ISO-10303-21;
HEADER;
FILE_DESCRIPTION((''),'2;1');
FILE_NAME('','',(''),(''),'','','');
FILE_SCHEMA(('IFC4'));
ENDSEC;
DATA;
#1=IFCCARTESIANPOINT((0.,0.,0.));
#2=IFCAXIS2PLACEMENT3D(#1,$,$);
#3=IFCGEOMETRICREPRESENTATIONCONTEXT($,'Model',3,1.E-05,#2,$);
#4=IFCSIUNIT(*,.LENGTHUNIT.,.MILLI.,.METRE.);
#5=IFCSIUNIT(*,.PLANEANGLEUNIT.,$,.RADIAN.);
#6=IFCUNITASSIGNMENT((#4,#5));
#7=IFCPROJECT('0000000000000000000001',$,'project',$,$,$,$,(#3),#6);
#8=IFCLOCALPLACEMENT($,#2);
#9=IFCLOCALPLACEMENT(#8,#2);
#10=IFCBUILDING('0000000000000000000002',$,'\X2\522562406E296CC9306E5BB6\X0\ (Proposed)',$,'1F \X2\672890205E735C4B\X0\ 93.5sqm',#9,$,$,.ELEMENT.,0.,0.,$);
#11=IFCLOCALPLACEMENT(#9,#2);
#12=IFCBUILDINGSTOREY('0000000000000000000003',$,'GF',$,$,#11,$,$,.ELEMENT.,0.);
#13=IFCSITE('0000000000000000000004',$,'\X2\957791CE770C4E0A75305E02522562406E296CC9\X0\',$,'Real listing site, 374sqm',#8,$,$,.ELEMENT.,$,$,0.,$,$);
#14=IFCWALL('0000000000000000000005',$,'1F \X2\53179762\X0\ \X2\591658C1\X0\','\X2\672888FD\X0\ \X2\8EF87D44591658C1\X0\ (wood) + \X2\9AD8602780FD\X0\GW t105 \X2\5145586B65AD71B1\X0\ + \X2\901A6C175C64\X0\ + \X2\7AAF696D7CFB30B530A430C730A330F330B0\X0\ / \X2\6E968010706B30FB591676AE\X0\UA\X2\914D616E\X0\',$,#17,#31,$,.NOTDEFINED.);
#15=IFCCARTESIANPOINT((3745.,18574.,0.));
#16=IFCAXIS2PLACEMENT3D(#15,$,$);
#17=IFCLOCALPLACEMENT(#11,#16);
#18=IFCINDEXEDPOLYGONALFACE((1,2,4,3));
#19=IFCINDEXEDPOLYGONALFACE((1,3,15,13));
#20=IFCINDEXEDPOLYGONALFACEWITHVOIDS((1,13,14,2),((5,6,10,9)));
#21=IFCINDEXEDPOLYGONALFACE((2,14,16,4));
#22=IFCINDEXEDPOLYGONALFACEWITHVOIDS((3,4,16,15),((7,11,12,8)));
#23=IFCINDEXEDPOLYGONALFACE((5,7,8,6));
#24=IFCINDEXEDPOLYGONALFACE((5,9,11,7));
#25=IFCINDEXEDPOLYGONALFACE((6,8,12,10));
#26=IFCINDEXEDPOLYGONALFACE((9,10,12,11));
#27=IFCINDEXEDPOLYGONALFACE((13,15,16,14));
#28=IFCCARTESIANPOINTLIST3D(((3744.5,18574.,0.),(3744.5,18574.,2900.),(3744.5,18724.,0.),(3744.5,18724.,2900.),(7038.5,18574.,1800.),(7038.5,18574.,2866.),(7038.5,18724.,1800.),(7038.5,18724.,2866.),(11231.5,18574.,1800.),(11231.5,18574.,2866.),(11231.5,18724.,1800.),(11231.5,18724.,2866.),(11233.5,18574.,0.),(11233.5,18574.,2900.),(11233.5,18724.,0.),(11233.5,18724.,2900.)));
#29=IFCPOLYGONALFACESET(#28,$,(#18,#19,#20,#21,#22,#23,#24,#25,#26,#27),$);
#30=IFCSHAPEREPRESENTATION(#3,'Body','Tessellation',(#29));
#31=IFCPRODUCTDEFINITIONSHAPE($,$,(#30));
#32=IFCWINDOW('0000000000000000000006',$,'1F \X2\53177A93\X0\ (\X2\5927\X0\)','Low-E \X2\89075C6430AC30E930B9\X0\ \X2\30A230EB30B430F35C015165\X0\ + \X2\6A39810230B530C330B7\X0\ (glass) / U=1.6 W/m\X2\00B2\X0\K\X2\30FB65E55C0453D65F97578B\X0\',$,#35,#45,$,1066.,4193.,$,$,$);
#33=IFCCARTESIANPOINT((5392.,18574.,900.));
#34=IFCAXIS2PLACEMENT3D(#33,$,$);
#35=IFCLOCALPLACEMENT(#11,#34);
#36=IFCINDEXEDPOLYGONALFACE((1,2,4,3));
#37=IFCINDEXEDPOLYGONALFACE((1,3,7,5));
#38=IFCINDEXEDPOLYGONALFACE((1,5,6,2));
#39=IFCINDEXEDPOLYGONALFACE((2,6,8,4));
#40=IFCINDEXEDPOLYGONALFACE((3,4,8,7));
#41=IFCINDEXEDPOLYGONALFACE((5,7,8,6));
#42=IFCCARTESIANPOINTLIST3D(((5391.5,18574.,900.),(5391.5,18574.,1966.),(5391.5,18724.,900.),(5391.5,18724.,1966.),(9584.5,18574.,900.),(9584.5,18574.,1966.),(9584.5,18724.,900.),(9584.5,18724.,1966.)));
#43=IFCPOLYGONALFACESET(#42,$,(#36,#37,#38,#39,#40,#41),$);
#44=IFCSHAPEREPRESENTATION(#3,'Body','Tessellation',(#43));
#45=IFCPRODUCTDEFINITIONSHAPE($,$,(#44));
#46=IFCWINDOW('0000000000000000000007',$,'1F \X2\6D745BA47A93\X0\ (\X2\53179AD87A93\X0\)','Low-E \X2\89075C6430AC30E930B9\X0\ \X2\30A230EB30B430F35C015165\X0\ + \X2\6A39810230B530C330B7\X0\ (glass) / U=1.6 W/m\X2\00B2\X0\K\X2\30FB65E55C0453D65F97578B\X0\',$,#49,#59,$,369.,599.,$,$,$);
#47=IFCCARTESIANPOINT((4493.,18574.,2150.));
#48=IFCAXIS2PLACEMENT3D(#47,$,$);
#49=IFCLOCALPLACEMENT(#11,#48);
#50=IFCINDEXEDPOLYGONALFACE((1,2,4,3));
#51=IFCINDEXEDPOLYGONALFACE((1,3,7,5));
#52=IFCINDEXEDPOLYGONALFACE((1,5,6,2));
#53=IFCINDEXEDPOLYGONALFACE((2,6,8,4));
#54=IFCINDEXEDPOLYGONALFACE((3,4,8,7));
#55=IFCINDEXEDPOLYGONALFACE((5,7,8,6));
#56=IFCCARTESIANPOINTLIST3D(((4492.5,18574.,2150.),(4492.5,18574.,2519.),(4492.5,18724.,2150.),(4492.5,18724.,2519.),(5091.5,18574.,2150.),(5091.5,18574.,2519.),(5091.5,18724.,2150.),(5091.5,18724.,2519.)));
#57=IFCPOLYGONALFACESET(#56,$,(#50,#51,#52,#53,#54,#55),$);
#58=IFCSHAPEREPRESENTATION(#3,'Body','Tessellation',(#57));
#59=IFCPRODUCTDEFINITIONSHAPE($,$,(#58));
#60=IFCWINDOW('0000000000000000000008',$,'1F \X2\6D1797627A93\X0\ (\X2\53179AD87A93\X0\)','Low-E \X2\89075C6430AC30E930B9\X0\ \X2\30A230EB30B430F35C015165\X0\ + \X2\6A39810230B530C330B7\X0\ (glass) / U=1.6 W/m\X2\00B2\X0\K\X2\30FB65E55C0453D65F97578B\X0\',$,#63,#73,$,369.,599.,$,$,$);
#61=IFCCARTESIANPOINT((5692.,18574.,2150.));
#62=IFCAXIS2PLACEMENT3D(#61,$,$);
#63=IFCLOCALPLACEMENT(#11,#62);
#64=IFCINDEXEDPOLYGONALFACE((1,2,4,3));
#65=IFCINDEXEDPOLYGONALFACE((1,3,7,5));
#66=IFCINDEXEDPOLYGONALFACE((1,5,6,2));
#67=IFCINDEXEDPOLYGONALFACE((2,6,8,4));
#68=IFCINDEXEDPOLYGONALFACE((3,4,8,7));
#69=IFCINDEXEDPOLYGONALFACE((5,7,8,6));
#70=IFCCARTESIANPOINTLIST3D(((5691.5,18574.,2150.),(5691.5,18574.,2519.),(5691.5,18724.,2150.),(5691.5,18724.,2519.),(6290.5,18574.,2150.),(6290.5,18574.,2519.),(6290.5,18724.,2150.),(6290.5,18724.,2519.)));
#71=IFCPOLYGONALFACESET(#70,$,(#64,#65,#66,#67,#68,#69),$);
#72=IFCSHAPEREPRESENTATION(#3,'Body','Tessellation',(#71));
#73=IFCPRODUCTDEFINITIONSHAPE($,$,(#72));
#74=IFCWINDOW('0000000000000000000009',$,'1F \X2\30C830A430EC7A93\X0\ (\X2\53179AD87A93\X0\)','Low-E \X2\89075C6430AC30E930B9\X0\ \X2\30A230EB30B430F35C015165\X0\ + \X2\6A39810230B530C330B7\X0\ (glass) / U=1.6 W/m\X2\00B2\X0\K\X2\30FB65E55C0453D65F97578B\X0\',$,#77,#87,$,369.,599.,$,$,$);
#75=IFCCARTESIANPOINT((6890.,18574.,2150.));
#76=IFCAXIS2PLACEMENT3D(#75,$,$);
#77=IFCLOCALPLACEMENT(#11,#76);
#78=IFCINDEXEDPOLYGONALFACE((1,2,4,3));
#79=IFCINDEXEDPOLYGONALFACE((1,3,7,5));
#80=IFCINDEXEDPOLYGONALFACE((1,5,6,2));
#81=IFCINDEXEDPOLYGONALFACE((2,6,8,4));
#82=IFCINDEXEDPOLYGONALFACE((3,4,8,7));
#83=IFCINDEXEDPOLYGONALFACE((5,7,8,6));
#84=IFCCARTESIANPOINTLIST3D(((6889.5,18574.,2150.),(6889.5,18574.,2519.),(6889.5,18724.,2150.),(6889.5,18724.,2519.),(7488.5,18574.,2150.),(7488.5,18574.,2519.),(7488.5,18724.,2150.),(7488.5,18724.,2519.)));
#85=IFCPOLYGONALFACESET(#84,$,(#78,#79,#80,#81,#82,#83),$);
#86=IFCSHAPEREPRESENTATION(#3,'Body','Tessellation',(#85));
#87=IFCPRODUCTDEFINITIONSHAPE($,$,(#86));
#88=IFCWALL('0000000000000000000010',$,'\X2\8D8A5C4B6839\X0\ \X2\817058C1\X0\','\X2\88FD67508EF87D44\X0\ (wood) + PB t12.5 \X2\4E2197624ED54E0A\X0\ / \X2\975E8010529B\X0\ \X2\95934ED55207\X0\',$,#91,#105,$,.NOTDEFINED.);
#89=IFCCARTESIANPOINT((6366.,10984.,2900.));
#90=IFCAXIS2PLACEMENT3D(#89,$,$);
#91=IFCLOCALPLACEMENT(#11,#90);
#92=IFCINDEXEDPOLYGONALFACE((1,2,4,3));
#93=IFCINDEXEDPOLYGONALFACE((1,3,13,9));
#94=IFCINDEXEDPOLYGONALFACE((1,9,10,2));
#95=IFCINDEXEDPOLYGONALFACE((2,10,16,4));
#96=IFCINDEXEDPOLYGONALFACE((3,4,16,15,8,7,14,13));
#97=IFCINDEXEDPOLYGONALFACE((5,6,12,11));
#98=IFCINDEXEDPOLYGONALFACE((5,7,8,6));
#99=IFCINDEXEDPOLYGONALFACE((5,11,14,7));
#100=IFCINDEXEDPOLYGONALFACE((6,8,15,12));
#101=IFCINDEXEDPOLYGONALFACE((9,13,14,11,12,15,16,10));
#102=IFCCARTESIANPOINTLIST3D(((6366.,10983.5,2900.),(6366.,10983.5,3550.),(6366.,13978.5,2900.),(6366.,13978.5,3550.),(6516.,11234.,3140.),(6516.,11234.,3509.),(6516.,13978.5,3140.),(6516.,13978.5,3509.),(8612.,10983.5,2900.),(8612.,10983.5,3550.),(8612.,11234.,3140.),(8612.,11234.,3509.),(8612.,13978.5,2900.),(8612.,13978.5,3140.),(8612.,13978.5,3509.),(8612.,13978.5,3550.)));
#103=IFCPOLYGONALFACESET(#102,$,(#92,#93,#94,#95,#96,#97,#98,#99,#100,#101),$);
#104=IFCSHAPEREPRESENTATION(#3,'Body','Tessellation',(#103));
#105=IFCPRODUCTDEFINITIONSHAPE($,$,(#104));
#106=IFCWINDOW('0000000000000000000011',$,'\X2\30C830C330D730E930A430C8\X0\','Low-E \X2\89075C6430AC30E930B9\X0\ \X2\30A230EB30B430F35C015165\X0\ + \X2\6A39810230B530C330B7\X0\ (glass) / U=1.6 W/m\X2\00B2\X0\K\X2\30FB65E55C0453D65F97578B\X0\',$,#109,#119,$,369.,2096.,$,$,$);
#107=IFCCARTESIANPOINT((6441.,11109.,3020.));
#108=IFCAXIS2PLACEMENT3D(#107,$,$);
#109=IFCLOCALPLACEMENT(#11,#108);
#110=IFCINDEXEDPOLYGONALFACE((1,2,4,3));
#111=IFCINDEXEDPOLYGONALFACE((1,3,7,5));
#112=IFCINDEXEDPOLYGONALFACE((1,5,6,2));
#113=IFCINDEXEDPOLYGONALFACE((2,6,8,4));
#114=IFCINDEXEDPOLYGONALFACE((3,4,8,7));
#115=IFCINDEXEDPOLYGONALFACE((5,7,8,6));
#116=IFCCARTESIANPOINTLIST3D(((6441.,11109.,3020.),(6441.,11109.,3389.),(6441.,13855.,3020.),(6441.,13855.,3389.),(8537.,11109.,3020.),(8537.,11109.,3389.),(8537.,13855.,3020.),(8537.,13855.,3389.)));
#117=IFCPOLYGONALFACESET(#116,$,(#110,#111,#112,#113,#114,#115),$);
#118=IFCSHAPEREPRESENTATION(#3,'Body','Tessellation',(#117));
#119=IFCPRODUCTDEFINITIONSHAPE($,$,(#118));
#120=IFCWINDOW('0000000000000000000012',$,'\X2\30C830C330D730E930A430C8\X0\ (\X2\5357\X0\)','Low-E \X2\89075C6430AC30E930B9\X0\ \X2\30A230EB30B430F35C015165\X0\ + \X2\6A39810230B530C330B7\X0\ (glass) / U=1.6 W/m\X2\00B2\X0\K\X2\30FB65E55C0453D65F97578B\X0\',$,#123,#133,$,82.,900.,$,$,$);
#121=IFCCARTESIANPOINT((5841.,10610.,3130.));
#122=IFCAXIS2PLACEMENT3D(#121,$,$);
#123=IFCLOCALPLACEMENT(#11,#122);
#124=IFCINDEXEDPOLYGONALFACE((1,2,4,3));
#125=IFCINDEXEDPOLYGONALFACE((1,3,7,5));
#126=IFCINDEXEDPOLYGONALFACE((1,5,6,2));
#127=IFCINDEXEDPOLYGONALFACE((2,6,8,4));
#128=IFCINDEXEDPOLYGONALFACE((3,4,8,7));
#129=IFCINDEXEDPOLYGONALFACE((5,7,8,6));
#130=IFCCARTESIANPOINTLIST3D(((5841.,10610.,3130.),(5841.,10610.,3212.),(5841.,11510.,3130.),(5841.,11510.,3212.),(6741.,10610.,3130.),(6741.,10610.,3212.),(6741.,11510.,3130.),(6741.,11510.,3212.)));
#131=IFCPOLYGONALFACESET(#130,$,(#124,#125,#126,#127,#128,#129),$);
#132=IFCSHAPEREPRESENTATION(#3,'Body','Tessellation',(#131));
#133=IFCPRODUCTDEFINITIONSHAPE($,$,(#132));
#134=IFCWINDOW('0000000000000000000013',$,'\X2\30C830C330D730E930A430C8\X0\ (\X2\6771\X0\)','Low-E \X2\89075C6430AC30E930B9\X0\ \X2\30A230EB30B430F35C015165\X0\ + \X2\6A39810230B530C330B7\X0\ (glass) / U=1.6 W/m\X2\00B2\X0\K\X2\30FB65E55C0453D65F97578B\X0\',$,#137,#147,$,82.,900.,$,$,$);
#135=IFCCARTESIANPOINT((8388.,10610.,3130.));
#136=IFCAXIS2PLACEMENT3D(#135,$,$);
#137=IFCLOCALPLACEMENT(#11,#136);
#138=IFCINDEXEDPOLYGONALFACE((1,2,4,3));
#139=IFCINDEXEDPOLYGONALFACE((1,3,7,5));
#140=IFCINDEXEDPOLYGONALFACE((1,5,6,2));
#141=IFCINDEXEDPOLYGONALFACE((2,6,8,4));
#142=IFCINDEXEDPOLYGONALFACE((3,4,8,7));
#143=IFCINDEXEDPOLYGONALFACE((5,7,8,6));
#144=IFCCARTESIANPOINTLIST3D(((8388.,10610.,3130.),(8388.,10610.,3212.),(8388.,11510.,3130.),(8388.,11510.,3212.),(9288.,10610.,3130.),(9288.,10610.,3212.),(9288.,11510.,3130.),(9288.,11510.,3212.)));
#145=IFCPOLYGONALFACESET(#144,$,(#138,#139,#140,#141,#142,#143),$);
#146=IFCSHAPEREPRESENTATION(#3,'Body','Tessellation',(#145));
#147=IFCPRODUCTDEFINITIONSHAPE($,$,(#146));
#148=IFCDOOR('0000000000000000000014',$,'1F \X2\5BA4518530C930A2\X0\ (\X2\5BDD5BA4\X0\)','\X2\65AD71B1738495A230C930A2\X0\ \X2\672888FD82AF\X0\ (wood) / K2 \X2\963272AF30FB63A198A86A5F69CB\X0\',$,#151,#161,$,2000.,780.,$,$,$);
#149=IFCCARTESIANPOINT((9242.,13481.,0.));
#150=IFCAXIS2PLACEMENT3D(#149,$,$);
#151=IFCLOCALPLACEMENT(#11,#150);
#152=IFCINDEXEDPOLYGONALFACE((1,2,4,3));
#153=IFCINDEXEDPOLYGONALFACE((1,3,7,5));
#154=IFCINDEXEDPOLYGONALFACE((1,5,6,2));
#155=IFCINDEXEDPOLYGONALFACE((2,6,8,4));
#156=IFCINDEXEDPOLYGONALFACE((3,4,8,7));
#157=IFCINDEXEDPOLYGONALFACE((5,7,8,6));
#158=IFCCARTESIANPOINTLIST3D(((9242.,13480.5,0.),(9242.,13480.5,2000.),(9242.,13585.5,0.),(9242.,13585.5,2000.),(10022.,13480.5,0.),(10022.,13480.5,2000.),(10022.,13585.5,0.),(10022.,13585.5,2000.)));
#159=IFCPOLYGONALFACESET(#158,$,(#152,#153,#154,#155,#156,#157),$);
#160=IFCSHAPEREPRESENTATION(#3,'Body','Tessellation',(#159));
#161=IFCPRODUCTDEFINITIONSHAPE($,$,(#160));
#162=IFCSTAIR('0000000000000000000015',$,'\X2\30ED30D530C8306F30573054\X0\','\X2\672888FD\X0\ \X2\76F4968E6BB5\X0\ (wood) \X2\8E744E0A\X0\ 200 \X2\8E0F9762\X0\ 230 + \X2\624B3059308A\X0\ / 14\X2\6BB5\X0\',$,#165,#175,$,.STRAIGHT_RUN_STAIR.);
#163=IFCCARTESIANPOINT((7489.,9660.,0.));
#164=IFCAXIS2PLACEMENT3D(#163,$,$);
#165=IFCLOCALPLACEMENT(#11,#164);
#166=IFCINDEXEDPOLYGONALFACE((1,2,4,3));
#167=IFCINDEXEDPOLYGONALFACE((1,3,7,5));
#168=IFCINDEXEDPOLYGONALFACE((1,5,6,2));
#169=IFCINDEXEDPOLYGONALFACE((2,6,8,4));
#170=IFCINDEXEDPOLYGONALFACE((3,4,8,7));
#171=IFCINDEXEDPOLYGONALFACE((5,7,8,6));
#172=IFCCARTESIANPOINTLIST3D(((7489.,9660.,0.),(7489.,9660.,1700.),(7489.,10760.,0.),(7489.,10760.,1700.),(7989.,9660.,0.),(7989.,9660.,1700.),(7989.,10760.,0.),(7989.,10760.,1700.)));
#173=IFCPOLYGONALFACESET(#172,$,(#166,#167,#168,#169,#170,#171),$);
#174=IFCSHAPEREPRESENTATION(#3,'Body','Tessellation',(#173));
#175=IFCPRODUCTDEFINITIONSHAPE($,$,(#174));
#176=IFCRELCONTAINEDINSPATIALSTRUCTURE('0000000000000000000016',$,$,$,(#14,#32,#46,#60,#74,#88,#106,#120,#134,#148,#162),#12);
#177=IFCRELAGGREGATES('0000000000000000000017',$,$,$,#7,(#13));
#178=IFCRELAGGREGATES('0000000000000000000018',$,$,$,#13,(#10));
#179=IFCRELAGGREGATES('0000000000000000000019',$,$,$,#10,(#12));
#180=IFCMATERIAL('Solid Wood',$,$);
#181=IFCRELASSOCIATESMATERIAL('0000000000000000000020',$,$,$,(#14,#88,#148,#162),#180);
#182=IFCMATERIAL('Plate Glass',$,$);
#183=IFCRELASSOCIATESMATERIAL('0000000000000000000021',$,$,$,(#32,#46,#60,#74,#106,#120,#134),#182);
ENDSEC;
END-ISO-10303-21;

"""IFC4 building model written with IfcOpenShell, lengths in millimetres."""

from ifc_helpers import new_model, si_unit, frame, frame_2d, origin, place, context, project, spatial, rectangle, extrude, material, element, fill, save


model = new_model("IFC4")

# Units and contexts
model_context = context("Model", 3, precision=1e-05, world=origin())
ifc_project = project(units=[si_unit("LENGTHUNIT", "METRE", prefix="MILLI"), si_unit("PLANEANGLEUNIT", "RADIAN")], contexts=[model_context])

# Site, building, storey
site_placement = place(None, origin())
site = spatial("IfcSite", under=ifc_project, at=site_placement, Name="長野県上田市別所温泉", ObjectType="Real listing site, 374sqm", CompositionType="ELEMENT", RefElevation=0.0)
building_placement = place(site_placement, origin())
building = spatial("IfcBuilding", under=site, at=building_placement, Name="別所温泉の家 (Proposed)", ObjectType="1F 木造平屋 93.5sqm", CompositionType="ELEMENT", ElevationOfRefHeight=0.0, ElevationOfTerrain=0.0)
storey_placement = place(building_placement, origin())
storey = spatial("IfcBuildingStorey", under=building, at=storey_placement, Name="GF", CompositionType="ELEMENT", Elevation=0.0)

# Shared definitions
ifc_material_1 = material(Name="Solid Wood")

# Wall, openings, windows
wall_1_placement = place(storey_placement, frame((3745.0, 18574.0, 0.0)))
wall_1 = element("IfcWall", 1, at=wall_1_placement, inside=storey, material=ifc_material_1, Name="1F 北面 外壁", Description="木製 軸組外壁 (wood) + 高性能GW t105 充填断熱 + 通気層 + 窯業系サイディング / 準耐火・外皮UA配慮", PredefinedType="NOTDEFINED", context=model_context, shape_type="SweptSolid", body=[
    extrude(rectangle(XDim=7489.0, YDim=150.0, at=frame_2d((3744.0, 75.0))), frame((3745.0, 18574.0, 0.0)), (0.0, 0.0, 1.0), 2900.0),
])
opening_1_placement = place(storey_placement, frame((5392.0, 18574.0, 900.0)))
opening_1 = element("IfcOpeningElement", 2, at=opening_1_placement, cuts=wall_1, PredefinedType="NOTDEFINED", context=model_context, shape_type="SweptSolid", body=[
    extrude(rectangle(XDim=4193.0, YDim=150.0, at=frame_2d((2096.0, 75.0))), frame((5392.0, 18574.0, 900.0)), (0.0, 0.0, 1.0), 1066.0),
])
opening_2_placement = place(storey_placement, frame((4493.0, 18574.0, 2150.0)))
opening_2 = element("IfcOpeningElement", 3, at=opening_2_placement, cuts=wall_1, PredefinedType="NOTDEFINED", context=model_context, shape_type="SweptSolid", body=[
    extrude(rectangle(XDim=599.0, YDim=150.0, at=frame_2d((299.0, 75.0))), frame((4493.0, 18574.0, 2150.0)), (0.0, 0.0, 1.0), 369.0),
])
opening_3_placement = place(storey_placement, frame((5692.0, 18574.0, 2150.0)))
opening_3 = element("IfcOpeningElement", 4, at=opening_3_placement, cuts=wall_1, PredefinedType="NOTDEFINED", context=model_context, shape_type="SweptSolid", body=[
    extrude(rectangle(XDim=599.0, YDim=150.0, at=frame_2d((299.0, 75.0))), frame((5692.0, 18574.0, 2150.0)), (0.0, 0.0, 1.0), 369.0),
])
opening_4_placement = place(storey_placement, frame((6890.0, 18574.0, 2150.0)))
opening_4 = element("IfcOpeningElement", 5, at=opening_4_placement, cuts=wall_1, PredefinedType="NOTDEFINED", context=model_context, shape_type="SweptSolid", body=[
    extrude(rectangle(XDim=599.0, YDim=150.0, at=frame_2d((299.0, 75.0))), frame((6890.0, 18574.0, 2150.0)), (0.0, 0.0, 1.0), 369.0),
])
ifc_material_2 = material(Name="Plate Glass")
window_1_placement = place(storey_placement, frame((5392.0, 18574.0, 900.0)))
window_1 = element("IfcWindow", 6, at=window_1_placement, inside=storey, material=ifc_material_2, Name="1F 北窓 (大)", Description="Low-E 複層ガラス アルゴン封入 + 樹脂サッシ (glass) / U=1.6 W/m²K・日射取得型", OverallHeight=1066.0, OverallWidth=4193.0, context=model_context, shape_type="SweptSolid", body=[
    extrude(rectangle(XDim=4193.0, YDim=150.0, at=frame_2d((2096.0, 75.0))), frame((5392.0, 18574.0, 900.0)), (0.0, 0.0, 1.0), 1066.0),
])
fill(opening_1, window_1)
window_2_placement = place(storey_placement, frame((4493.0, 18574.0, 2150.0)))
window_2 = element("IfcWindow", 7, at=window_2_placement, inside=storey, material=ifc_material_2, Name="1F 浴室窓 (北高窓)", Description="Low-E 複層ガラス アルゴン封入 + 樹脂サッシ (glass) / U=1.6 W/m²K・日射取得型", OverallHeight=369.0, OverallWidth=599.0, context=model_context, shape_type="SweptSolid", body=[
    extrude(rectangle(XDim=599.0, YDim=150.0, at=frame_2d((299.0, 75.0))), frame((4493.0, 18574.0, 2150.0)), (0.0, 0.0, 1.0), 369.0),
])
fill(opening_2, window_2)
window_3_placement = place(storey_placement, frame((5692.0, 18574.0, 2150.0)))
window_3 = element("IfcWindow", 8, at=window_3_placement, inside=storey, material=ifc_material_2, Name="1F 洗面窓 (北高窓)", Description="Low-E 複層ガラス アルゴン封入 + 樹脂サッシ (glass) / U=1.6 W/m²K・日射取得型", OverallHeight=369.0, OverallWidth=599.0, context=model_context, shape_type="SweptSolid", body=[
    extrude(rectangle(XDim=599.0, YDim=150.0, at=frame_2d((299.0, 75.0))), frame((5692.0, 18574.0, 2150.0)), (0.0, 0.0, 1.0), 369.0),
])
fill(opening_3, window_3)
window_4_placement = place(storey_placement, frame((6890.0, 18574.0, 2150.0)))
window_4 = element("IfcWindow", 9, at=window_4_placement, inside=storey, material=ifc_material_2, Name="1F トイレ窓 (北高窓)", Description="Low-E 複層ガラス アルゴン封入 + 樹脂サッシ (glass) / U=1.6 W/m²K・日射取得型", OverallHeight=369.0, OverallWidth=599.0, context=model_context, shape_type="SweptSolid", body=[
    extrude(rectangle(XDim=599.0, YDim=150.0, at=frame_2d((299.0, 75.0))), frame((6890.0, 18574.0, 2150.0)), (0.0, 0.0, 1.0), 369.0),
])
fill(opening_4, window_4)

# Wall, openings, windows
wall_2_placement = place(storey_placement, frame((6366.0, 10984.0, 2900.0)))
wall_2 = element("IfcWall", 10, at=wall_2_placement, inside=storey, material=ifc_material_1, Name="越屋根 腰壁", Description="製材軸組 (wood) + PB t12.5 両面仕上 / 非耐力 間仕切", PredefinedType="NOTDEFINED", context=model_context, shape_type="SweptSolid", body=[
    extrude(rectangle(XDim=2246.0, YDim=2995.0, at=frame_2d((1123.0, 1497.0))), frame((6366.0, 10984.0, 2900.0)), (0.0, 0.0, 1.0), 650.0),
])
opening_5_placement = place(storey_placement, frame((6441.0, 11109.0, 3020.0)))
opening_5 = element("IfcOpeningElement", 11, at=opening_5_placement, cuts=wall_2, PredefinedType="NOTDEFINED", context=model_context, shape_type="SweptSolid", body=[
    extrude(rectangle(XDim=2096.0, YDim=2746.0, at=frame_2d((1048.0, 1373.0))), frame((6441.0, 11109.0, 3020.0)), (0.0, 0.0, 1.0), 369.0),
])
opening_6_placement = place(storey_placement, frame((5841.0, 10610.0, 3130.0)))
opening_6 = element("IfcOpeningElement", 12, at=opening_6_placement, cuts=wall_2, PredefinedType="NOTDEFINED", context=model_context, shape_type="SweptSolid", body=[
    extrude(rectangle(XDim=900.0, YDim=900.0, at=frame_2d((450.0, 450.0))), frame((5841.0, 10610.0, 3130.0)), (0.0, 0.0, 1.0), 82.0),
])
opening_7_placement = place(storey_placement, frame((8388.0, 10610.0, 3130.0)))
opening_7 = element("IfcOpeningElement", 13, at=opening_7_placement, cuts=wall_2, PredefinedType="NOTDEFINED", context=model_context, shape_type="SweptSolid", body=[
    extrude(rectangle(XDim=900.0, YDim=900.0, at=frame_2d((450.0, 450.0))), frame((8388.0, 10610.0, 3130.0)), (0.0, 0.0, 1.0), 82.0),
])
window_5_placement = place(storey_placement, frame((6441.0, 11109.0, 3020.0)))
window_5 = element("IfcWindow", 14, at=window_5_placement, inside=storey, material=ifc_material_2, Name="トップライト", Description="Low-E 複層ガラス アルゴン封入 + 樹脂サッシ (glass) / U=1.6 W/m²K・日射取得型", OverallHeight=369.0, OverallWidth=2096.0, context=model_context, shape_type="SweptSolid", body=[
    extrude(rectangle(XDim=2096.0, YDim=2746.0, at=frame_2d((1048.0, 1373.0))), frame((6441.0, 11109.0, 3020.0)), (0.0, 0.0, 1.0), 369.0),
])
fill(opening_5, window_5)
window_6_placement = place(storey_placement, frame((5841.0, 10610.0, 3130.0)))
window_6 = element("IfcWindow", 15, at=window_6_placement, inside=storey, material=ifc_material_2, Name="トップライト (南)", Description="Low-E 複層ガラス アルゴン封入 + 樹脂サッシ (glass) / U=1.6 W/m²K・日射取得型", OverallHeight=82.0, OverallWidth=900.0, context=model_context, shape_type="SweptSolid", body=[
    extrude(rectangle(XDim=900.0, YDim=900.0, at=frame_2d((450.0, 450.0))), frame((5841.0, 10610.0, 3130.0)), (0.0, 0.0, 1.0), 82.0),
])
fill(opening_6, window_6)
window_7_placement = place(storey_placement, frame((8388.0, 10610.0, 3130.0)))
window_7 = element("IfcWindow", 16, at=window_7_placement, inside=storey, material=ifc_material_2, Name="トップライト (東)", Description="Low-E 複層ガラス アルゴン封入 + 樹脂サッシ (glass) / U=1.6 W/m²K・日射取得型", OverallHeight=82.0, OverallWidth=900.0, context=model_context, shape_type="SweptSolid", body=[
    extrude(rectangle(XDim=900.0, YDim=900.0, at=frame_2d((450.0, 450.0))), frame((8388.0, 10610.0, 3130.0)), (0.0, 0.0, 1.0), 82.0),
])
fill(opening_7, window_7)

# Door
door_1_placement = place(storey_placement, frame((9242.0, 13481.0, 0.0)))
element("IfcDoor", 17, at=door_1_placement, inside=storey, material=ifc_material_1, Name="1F 室内ドア (寝室)", Description="断熱玄関ドア 木製芯 (wood) / K2 防犯・採風機構", OverallHeight=2000.0, OverallWidth=780.0, context=model_context, shape_type="SweptSolid", body=[
    extrude(rectangle(XDim=780.0, YDim=105.0, at=frame_2d((390.0, 52.0))), frame((9242.0, 13481.0, 0.0)), (0.0, 0.0, 1.0), 2000.0),
])

# Stair
stair_placement = place(storey_placement, frame((7489.0, 9660.0, 0.0)))
element("IfcStair", 18, at=stair_placement, inside=storey, material=ifc_material_1, Name="ロフトはしご", Description="木製 直階段 (wood) 蹴上 200 踏面 230 + 手すり / 14段", PredefinedType="STRAIGHT_RUN_STAIR", context=model_context, shape_type="SweptSolid", body=[
    extrude(rectangle(XDim=500.0, YDim=1100.0, at=frame_2d((250.0, 550.0))), frame((7489.0, 9660.0, 0.0)), (0.0, 0.0, 1.0), 1700.0),
])

save(model, "model.ifc")
